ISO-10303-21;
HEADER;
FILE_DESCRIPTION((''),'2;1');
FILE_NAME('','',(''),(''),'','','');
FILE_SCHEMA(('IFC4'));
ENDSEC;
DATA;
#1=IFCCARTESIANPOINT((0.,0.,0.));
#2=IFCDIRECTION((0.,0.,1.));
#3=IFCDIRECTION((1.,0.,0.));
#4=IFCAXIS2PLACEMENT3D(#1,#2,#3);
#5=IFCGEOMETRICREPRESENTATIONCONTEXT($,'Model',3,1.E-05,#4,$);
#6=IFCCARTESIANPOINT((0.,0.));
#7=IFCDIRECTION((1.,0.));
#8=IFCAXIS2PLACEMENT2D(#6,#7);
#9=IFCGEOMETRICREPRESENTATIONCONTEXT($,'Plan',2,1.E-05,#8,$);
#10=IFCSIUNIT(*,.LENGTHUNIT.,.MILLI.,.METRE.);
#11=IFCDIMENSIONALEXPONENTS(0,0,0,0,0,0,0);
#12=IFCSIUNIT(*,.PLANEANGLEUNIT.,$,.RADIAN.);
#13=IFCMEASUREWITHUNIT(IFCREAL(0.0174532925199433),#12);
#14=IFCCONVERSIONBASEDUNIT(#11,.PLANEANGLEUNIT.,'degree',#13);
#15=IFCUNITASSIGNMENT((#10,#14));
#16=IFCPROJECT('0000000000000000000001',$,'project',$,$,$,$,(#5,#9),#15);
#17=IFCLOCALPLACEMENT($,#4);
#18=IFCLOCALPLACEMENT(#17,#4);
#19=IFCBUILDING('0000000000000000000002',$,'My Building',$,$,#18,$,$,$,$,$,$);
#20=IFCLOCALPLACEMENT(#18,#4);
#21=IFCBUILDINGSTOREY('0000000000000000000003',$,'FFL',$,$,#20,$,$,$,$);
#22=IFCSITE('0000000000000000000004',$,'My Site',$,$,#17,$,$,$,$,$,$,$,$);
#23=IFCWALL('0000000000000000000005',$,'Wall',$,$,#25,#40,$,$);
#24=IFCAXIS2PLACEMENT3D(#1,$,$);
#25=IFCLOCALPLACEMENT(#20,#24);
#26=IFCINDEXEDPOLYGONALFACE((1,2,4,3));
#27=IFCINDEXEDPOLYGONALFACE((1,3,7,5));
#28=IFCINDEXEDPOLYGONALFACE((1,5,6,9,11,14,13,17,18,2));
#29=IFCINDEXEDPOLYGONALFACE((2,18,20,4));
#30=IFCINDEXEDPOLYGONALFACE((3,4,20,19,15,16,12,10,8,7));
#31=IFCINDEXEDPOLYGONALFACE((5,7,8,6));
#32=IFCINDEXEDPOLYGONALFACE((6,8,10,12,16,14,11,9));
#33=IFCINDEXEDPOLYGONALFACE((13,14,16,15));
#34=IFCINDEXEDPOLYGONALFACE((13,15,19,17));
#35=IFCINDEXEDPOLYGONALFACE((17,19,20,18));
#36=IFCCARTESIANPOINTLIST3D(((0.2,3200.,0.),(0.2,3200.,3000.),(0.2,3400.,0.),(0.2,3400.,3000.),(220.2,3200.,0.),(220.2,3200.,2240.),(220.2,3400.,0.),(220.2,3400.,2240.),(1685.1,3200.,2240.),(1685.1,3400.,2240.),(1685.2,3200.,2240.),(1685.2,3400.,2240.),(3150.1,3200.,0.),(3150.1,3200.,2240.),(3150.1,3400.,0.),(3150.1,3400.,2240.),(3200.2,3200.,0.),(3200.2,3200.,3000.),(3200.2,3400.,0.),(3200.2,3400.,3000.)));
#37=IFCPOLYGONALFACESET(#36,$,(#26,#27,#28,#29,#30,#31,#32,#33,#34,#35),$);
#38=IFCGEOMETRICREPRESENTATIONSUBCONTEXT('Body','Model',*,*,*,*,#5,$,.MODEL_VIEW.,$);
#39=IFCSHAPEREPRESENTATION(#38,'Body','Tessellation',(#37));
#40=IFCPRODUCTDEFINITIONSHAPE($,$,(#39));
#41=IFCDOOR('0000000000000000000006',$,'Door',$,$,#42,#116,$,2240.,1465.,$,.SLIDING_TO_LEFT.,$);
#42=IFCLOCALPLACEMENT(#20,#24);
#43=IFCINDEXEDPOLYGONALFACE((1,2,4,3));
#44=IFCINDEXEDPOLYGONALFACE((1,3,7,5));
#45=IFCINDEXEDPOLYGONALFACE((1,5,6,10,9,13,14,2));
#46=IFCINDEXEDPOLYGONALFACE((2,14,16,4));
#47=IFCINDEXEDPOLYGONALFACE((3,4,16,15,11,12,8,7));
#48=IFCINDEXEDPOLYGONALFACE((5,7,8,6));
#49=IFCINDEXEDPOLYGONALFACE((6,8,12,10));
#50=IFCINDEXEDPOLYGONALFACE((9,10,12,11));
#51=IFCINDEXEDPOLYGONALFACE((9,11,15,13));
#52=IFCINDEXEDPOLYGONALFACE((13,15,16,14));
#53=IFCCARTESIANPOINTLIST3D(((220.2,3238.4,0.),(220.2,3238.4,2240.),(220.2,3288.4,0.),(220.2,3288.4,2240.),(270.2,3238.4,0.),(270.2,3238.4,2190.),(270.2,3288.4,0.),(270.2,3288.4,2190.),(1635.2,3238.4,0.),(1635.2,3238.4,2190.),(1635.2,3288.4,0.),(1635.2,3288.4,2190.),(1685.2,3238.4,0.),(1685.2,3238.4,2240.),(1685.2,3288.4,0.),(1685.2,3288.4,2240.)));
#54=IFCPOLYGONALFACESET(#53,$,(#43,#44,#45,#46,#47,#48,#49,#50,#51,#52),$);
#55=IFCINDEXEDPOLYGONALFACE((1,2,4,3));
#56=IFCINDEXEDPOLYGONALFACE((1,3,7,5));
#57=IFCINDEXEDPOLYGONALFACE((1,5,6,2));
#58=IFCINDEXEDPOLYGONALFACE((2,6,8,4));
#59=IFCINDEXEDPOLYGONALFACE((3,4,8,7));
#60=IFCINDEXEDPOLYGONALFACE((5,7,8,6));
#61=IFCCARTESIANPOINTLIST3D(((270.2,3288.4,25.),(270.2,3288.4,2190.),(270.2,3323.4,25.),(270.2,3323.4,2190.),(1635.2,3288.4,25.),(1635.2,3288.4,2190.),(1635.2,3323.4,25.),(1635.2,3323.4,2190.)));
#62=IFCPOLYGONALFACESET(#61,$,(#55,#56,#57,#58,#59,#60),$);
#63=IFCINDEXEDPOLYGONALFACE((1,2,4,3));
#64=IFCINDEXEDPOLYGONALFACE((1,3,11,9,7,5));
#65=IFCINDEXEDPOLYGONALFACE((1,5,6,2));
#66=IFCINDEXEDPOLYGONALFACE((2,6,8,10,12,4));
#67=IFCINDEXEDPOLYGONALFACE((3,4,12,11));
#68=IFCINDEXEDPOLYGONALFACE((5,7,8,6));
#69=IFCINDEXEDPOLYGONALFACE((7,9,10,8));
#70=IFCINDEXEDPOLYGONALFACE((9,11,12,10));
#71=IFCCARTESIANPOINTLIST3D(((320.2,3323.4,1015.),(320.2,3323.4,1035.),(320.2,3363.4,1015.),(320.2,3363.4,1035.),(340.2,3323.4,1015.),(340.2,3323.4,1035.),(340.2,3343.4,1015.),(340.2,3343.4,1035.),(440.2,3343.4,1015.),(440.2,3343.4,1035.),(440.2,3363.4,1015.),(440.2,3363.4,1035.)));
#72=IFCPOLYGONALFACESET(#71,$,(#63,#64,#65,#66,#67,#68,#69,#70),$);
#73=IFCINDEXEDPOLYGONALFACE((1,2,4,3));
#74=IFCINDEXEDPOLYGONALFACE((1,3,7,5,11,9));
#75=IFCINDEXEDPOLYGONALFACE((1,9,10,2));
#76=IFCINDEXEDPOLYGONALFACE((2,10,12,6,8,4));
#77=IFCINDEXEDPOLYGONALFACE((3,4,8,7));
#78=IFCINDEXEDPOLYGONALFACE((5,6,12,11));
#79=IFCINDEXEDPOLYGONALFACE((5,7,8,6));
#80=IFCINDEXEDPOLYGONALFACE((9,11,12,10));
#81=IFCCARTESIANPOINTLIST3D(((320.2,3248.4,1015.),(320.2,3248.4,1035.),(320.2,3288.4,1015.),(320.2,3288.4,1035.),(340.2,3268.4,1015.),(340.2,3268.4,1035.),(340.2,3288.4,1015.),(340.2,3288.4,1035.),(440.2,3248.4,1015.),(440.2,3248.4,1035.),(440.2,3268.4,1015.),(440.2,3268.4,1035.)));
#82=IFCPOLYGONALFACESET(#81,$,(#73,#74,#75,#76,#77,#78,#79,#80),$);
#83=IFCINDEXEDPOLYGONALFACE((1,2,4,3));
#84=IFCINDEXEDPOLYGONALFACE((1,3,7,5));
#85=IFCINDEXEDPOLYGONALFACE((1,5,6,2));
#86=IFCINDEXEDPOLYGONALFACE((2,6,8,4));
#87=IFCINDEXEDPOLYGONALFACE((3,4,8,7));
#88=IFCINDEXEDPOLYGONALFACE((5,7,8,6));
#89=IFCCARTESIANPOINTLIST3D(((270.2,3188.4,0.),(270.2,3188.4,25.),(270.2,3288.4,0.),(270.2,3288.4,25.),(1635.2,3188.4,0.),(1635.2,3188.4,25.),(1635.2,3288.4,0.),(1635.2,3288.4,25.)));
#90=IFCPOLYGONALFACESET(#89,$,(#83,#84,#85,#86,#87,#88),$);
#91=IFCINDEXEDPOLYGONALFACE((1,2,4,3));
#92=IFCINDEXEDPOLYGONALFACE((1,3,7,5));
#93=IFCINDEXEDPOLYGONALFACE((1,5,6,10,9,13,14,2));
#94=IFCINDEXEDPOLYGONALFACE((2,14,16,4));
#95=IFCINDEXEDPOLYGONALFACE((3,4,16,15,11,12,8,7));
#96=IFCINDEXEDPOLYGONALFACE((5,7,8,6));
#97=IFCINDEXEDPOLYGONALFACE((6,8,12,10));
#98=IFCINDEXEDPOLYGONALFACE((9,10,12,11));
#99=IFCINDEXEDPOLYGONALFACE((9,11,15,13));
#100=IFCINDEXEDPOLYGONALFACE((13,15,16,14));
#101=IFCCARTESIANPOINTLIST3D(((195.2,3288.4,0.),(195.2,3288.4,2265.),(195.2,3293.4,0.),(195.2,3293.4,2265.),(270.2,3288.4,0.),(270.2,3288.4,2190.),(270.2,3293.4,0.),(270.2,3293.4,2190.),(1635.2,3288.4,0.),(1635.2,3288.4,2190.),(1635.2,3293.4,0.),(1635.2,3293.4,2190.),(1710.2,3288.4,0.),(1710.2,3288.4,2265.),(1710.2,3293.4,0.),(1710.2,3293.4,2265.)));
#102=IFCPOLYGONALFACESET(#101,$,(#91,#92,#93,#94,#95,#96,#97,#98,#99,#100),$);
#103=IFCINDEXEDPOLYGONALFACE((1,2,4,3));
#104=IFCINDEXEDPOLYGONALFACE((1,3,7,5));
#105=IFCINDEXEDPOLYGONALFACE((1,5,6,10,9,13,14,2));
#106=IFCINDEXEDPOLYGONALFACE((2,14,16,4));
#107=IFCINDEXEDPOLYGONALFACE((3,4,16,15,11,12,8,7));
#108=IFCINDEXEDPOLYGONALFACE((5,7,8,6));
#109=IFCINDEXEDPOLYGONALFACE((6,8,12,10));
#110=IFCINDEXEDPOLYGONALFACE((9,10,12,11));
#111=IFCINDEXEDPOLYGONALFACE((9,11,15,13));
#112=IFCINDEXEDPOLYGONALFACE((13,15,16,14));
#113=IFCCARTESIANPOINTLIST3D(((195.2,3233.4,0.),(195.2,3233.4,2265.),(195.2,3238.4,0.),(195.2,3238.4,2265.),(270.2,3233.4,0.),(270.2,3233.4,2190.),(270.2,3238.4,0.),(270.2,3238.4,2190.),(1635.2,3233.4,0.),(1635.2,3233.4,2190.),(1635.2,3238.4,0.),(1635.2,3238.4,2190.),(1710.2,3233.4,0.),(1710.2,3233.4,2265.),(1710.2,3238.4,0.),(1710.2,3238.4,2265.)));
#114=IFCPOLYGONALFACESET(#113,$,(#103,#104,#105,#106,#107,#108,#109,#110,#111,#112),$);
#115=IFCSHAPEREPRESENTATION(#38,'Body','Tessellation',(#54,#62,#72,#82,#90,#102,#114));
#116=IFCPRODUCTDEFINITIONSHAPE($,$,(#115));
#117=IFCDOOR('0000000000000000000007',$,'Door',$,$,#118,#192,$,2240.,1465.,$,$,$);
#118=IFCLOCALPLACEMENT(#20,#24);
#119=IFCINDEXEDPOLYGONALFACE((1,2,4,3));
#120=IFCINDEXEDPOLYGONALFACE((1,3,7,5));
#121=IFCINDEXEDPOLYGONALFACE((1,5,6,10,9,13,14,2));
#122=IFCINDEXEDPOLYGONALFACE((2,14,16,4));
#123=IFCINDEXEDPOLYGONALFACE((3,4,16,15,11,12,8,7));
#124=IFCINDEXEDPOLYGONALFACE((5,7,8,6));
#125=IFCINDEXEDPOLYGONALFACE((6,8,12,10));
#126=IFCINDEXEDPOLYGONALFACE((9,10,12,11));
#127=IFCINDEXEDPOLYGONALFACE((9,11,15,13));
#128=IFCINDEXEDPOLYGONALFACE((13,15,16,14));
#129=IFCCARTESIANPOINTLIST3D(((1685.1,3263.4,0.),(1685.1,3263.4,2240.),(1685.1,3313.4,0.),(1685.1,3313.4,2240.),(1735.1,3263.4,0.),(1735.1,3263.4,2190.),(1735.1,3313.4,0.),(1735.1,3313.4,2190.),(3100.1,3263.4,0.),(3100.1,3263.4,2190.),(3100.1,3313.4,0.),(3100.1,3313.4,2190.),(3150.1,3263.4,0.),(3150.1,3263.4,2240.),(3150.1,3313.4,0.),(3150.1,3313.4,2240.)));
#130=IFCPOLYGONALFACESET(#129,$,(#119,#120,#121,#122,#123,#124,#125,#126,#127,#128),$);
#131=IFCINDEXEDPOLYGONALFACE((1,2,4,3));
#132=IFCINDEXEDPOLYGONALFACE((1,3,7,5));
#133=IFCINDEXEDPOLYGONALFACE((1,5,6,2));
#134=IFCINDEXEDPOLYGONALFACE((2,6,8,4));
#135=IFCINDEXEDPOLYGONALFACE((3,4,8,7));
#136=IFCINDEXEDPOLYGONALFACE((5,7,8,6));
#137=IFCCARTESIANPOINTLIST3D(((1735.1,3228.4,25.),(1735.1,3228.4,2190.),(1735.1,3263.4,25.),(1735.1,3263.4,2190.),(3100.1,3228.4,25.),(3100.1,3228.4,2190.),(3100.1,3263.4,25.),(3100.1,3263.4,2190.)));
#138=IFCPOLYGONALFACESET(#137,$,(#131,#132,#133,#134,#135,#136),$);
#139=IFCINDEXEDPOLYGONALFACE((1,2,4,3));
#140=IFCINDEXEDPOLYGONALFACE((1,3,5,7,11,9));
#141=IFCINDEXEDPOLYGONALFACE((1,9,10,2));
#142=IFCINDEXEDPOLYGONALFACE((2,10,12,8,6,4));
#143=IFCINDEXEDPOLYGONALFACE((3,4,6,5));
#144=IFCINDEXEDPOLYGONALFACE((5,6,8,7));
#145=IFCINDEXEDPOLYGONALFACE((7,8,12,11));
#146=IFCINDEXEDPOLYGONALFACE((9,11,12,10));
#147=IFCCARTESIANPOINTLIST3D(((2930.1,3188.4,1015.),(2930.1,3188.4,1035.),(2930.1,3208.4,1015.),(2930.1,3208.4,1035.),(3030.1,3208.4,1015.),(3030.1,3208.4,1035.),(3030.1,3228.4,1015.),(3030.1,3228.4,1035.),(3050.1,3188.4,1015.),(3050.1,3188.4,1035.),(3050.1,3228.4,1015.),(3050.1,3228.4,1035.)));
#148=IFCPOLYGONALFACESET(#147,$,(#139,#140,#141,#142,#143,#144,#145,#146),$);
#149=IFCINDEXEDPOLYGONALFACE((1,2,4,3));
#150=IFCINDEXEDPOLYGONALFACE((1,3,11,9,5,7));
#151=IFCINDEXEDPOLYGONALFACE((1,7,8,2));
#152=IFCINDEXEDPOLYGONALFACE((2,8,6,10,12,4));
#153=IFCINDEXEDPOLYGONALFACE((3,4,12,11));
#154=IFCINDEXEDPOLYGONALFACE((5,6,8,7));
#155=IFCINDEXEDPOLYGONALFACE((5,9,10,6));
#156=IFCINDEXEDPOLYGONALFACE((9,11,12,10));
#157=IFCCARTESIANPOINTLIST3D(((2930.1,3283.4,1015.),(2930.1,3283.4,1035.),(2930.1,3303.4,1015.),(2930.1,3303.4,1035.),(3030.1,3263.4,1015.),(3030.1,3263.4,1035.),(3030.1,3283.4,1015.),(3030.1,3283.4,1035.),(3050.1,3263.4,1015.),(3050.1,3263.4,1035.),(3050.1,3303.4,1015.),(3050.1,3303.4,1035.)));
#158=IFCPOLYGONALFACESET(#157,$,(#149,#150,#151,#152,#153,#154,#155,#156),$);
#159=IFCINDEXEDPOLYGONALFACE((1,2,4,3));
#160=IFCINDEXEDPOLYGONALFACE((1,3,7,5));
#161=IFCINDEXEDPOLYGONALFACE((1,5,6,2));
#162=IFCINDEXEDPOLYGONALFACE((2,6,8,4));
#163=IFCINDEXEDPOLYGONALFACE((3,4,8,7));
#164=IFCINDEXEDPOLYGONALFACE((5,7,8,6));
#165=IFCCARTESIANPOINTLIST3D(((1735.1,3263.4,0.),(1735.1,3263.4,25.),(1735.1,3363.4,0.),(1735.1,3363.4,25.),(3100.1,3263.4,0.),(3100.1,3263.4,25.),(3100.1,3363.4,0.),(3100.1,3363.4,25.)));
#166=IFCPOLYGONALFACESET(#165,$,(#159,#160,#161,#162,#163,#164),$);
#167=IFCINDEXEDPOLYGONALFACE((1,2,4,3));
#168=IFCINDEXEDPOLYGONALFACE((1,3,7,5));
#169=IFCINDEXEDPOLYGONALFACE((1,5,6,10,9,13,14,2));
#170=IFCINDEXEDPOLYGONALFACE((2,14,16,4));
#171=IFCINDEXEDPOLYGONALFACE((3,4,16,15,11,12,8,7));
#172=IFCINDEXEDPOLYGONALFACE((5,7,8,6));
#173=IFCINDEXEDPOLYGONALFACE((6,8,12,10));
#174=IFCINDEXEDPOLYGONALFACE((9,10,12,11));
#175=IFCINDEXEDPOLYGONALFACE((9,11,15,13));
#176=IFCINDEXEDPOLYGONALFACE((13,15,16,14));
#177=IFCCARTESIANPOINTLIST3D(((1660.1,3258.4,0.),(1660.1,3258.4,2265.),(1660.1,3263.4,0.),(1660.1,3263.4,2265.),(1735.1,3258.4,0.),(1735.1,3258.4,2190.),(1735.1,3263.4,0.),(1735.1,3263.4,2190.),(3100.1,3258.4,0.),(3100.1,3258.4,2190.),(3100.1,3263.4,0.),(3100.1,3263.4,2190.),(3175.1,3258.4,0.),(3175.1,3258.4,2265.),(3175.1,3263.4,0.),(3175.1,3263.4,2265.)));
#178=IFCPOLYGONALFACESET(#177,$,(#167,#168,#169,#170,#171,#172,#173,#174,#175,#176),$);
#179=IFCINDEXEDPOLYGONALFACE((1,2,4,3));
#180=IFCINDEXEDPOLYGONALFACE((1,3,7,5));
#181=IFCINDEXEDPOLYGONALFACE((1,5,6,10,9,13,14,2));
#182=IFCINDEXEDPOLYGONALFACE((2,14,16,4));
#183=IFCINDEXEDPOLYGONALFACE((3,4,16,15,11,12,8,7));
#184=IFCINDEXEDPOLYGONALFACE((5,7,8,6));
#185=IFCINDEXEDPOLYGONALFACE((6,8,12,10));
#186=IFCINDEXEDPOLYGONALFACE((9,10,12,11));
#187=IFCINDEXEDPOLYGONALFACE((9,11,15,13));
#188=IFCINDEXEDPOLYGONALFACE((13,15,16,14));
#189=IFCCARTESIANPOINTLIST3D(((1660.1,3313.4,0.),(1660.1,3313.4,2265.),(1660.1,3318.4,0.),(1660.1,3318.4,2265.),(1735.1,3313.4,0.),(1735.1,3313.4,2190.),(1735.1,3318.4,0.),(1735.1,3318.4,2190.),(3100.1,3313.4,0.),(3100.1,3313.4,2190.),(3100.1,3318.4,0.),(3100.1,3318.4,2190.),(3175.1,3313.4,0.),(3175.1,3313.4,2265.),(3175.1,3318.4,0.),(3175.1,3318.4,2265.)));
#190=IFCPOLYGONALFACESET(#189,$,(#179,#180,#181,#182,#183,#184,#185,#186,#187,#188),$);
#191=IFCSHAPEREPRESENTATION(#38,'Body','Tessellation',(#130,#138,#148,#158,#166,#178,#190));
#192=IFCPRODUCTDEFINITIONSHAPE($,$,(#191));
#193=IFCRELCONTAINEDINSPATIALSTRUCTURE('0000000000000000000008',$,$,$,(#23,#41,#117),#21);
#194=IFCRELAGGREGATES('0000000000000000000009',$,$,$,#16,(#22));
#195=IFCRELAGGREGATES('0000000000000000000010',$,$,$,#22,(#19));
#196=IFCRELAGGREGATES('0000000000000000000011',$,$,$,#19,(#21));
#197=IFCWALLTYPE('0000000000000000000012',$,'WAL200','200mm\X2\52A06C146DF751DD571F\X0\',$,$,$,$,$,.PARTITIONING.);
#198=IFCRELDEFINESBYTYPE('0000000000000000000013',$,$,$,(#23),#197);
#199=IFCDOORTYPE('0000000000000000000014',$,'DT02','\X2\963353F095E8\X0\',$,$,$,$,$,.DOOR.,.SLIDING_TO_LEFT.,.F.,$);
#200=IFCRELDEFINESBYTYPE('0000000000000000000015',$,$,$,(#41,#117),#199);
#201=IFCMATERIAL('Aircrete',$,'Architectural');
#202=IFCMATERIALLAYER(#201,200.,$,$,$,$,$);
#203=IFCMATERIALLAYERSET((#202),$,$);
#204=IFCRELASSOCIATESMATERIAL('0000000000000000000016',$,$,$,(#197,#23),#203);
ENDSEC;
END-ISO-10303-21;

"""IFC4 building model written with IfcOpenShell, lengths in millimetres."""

from ifc_helpers import new_model, entity, si_unit, converted_unit, frame, origin_with_axes, origin_2d_with_axis, place, context, subcontext, project, spatial, line, indexed_curve, outline, extrude, shape, source, transform, mapped, material, layer, layer_set, layer_usage, type_object, type_shapes, element, fill, save


model = new_model("IFC4")

# Units and contexts
model_context = context("Model", 3, precision=1e-05, world=origin_with_axes())
plan_context = context("Plan", 2, precision=1e-05, world=origin_2d_with_axis())
body_context_1 = subcontext(model_context, "Body", "Model", "MODEL_VIEW")
body_context_2 = subcontext(plan_context, "Body", "Plan", "PLAN_VIEW")
ifc_project = project(units=[si_unit("LENGTHUNIT", "METRE", prefix="MILLI"), converted_unit("PLANEANGLEUNIT", "degree", entity("IfcReal", 0.0174532925199433), si_unit("PLANEANGLEUNIT", "RADIAN"), dimensions=[0, 0, 0, 0, 0, 0, 0])], contexts=[model_context, plan_context])

# Site, building, storey
site_placement = place(None, origin_with_axes())
site = spatial("IfcSite", under=ifc_project, at=site_placement, Name="My Site")
building_placement = place(site_placement, origin_with_axes())
building = spatial("IfcBuilding", under=site, at=building_placement, Name="My Building")
storey_placement = place(building_placement, origin_with_axes())
storey = spatial("IfcBuildingStorey", under=building, at=storey_placement, Name="FFL")

# Shared definitions
ifc_material_1 = material(Name="Aircrete", Category="Architectural")

# Wall, openings, doors
ifc_layer_1 = layer(ifc_material_1, 200.0)
ifc_layer_set_1 = layer_set([ifc_layer_1])
ifc_layer_usage_1 = layer_usage(ifc_layer_set_1, "AXIS2", "NEGATIVE", 0.0)
wall_type_1 = type_object("IfcWallType", Name="WAL200", Description="200mm加气混凝土", PredefinedType="PARTITIONING", material=ifc_layer_set_1)
wall_1_placement = place(storey_placement, frame((3200.2, 3200.0, 0.0), z_axis=(0.0, 0.0, 1.0), x_axis=(-1.0, 0.0, 0.0)))
wall_1 = element("IfcWall", 1, at=wall_1_placement, inside=storey, type_object=wall_type_1, material=ifc_layer_usage_1, Name="Wall", context=body_context_1, shape_type="SweptSolid", body=[
    extrude(outline(indexed_curve([(0.0, -200.0), (0.0, 0.0), (3200.0, 0.0), (3200.0, -200.0)], segments=[line(1, 2, 3, 4, 1)])), origin_with_axes(), (0.0, 0.0, 1.0), 3000.0),
])
shared_shape_1 = source(origin_with_axes(), body_context_1, "Body", "SweptSolid", [
    extrude(outline(indexed_curve([(0.0, 0.0), (1465.0, 0.0), (1465.0, 2240.0), (0.0, 2240.0)], segments=[line(1, 2, 3, 4, 1)])), frame((0.0, -600.0, 0.0), z_axis=(0.0, -1.0, 0.0), x_axis=(1.0, 0.0, 0.0)), (0.0, 0.0, -1.0), 1200.0),
])
opening_1_placement = place(wall_1_placement, frame((1515.0, -88.5, 0.0), z_axis=(0.0, 0.0, 1.0), x_axis=(1.0, -0.000003, 0.0)))
opening_1 = element("IfcOpeningElement", 2, at=opening_1_placement, cuts=wall_1, PredefinedType="OPENING", context=body_context_1, shape_type="MappedRepresentation", body=[
    mapped(shared_shape_1, transform((0.0, 0.0, 0.0), x_axis=(1.0, 0.0, 0.0), y_axis=(0.0, 1.0, 0.0), z_axis=(0.0, 0.0, 1.0), scale=1.0)),
])
opening_2_placement = place(wall_1_placement, frame((1515.1, -63.5, 0.0), z_axis=(0.0, 0.0, 1.0), x_axis=(-1.0, 0.000001, 0.0)))
opening_2 = element("IfcOpeningElement", 3, at=opening_2_placement, cuts=wall_1, PredefinedType="OPENING", context=body_context_1, shape_type="MappedRepresentation", body=[
    mapped(shared_shape_1, transform((0.0, 0.0, 0.0), x_axis=(1.0, 0.0, 0.0), y_axis=(0.0, 1.0, 0.0), z_axis=(0.0, 0.0, 1.0), scale=1.0)),
])
door_type_1 = type_object("IfcDoorType", Name="DT02", Description="阳台门", OperationType="SLIDING_TO_LEFT", ParameterTakesPrecedence=False, PredefinedType="DOOR")
shared_shape_2 = source(origin_with_axes(), body_context_1, "Body", "SweptSolid", [
    extrude(outline(indexed_curve([(0.0, 0.0), (0.0, 2240.0), (1465.0, 2240.0), (1465.0, 0.0), (1415.0, 0.0), (1415.0, 2190.0), (50.0, 2190.0), (50.0, 0.0)], segments=[line(1, 2, 3, 4, 5, 6, 7, 8, 1)])), frame((0.0, 0.0, 0.0), z_axis=(0.0, -1.0, 0.0), x_axis=(1.0, 0.0, 0.0)), (0.0, 0.0, -1.0), 50.0),
    extrude(outline(indexed_curve([(0.0, 0.0), (1365.0, 0.0), (1365.0, 35.0), (0.0, 35.0)], segments=[line(1, 2, 3, 4, 1)])), frame((50.0, -35.0, 25.0), z_axis=(0.0, 0.0, 1.0), x_axis=(1.0, 0.0, 0.0)), (0.0, 0.0, 1.0), 2165.0),
    extrude(outline(indexed_curve([(0.0, 0.0), (0.0, -40.0), (-120.0, -40.0), (-120.0, -20.0), (-20.0, -20.0), (-20.0, 0.0)], segments=[line(1, 2, 3, 4, 5, 6, 1)])), frame((1365.0, -35.0, 1015.0), z_axis=(0.0, 0.0, 1.0), x_axis=(1.0, 0.0, 0.0)), (0.0, 0.0, 1.0), 20.0),
    extrude(outline(indexed_curve([(0.0, 0.0), (0.0, 40.0), (-120.0, 40.0), (-120.0, 20.0), (-20.0, 20.0), (-20.0, 0.0)], segments=[line(1, 2, 3, 4, 5, 6, 1)])), frame((1365.0, 0.0, 1015.0), z_axis=(0.0, 0.0, 1.0), x_axis=(1.0, 0.0, 0.0)), (0.0, 0.0, 1.0), 20.0),
    extrude(outline(indexed_curve([(0.0, 0.0), (1365.0, 0.0), (1365.0, 100.0), (0.0, 100.0)], segments=[line(1, 2, 3, 4, 1)])), frame((50.0, 0.0, 0.0), z_axis=(0.0, 0.0, 1.0), x_axis=(1.0, 0.0, 0.0)), (0.0, 0.0, 1.0), 25.0),
    extrude(outline(indexed_curve([(0.0, 0.0), (0.0, 2265.0), (1515.0, 2265.0), (1515.0, 0.0), (1440.0, 0.0), (1440.0, 2190.0), (75.0, 2190.0), (75.0, 0.0)], segments=[line(1, 2, 3, 4, 5, 6, 7, 8, 1)])), frame((-25.0, -5.0, 0.0), z_axis=(0.0, -1.0, 0.0), x_axis=(1.0, 0.0, 0.0)), (0.0, 0.0, -1.0), 5.0),
    extrude(outline(indexed_curve([(75.0, 0.0), (75.0, 2190.0), (1440.0, 2190.0), (1440.0, 0.0), (1515.0, 0.0), (1515.0, 2265.0), (0.0, 2265.0), (0.0, 0.0), (75.0, 0.0)])), frame((-25.0, 50.0, 0.0), z_axis=(0.0, -1.0, 0.0), x_axis=(1.0, 0.0, 0.0)), (0.0, 0.0, -1.0), 5.0),
])
shared_shape_3 = source(origin_with_axes(), body_context_2, "Body", "Curve2D", [
    entity("IfcIndexedPolyCurve", entity("IfcCartesianPointList2D", [[0.0, 0.0], [50.0, 0.0], [50.0, 50.0], [0.0, 50.0]]), [entity("IfcLineIndex", [1, 2, 3, 4, 1])]),
    entity("IfcIndexedPolyCurve", entity("IfcCartesianPointList2D", [[1465.0, 0.0], [1415.0, 0.0], [1415.0, 50.0], [1465.0, 50.0]]), [entity("IfcLineIndex", [1, 2, 3, 4, 1])]),
    entity("IfcIndexedPolyCurve", entity("IfcCartesianPointList2D", [[-632.5, -35.0], [732.5, -35.0], [732.5, 0.0], [-632.5, 0.0]]), [entity("IfcLineIndex", [1, 2, 3, 4, 1])]),
])
type_shapes(door_type_1, [shared_shape_2, shared_shape_3])
door_1_placement = place(opening_1_placement, frame((0.0, 0.0, 0.0), z_axis=(0.0, 0.0, 1.0), x_axis=(1.0, 0.0, 0.0)))
door_1 = element("IfcDoor", 4, at=door_1_placement, inside=storey, type_object=door_type_1, Name="Door", OperationType="SLIDING_TO_LEFT", OverallHeight=2240.0, OverallWidth=1465.0, shapes=[
    shape(body_context_1, "Body", "MappedRepresentation", [mapped(shared_shape_2, transform((0.0, 0.0, 0.0), x_axis=(1.0, 0.0, 0.0), y_axis=(0.0, 1.0, 0.0), z_axis=(0.0, 0.0, 1.0), scale=1.0))]),
    shape(body_context_2, "Body", "MappedRepresentation", [mapped(shared_shape_3, transform((0.0, 0.0, 0.0), x_axis=(1.0, 0.0, 0.0), y_axis=(0.0, 1.0, 0.0), z_axis=(0.0, 0.0, 1.0), scale=1.0))]),
])
fill(opening_1, door_1)
door_2_placement = place(opening_2_placement, frame((0.0, 0.0, 0.0), z_axis=(0.0, 0.0, 1.0), x_axis=(1.0, 0.0, 0.0)))
door_2 = element("IfcDoor", 5, at=door_2_placement, inside=storey, type_object=door_type_1, Name="Door", OverallHeight=2240.0, OverallWidth=1465.0, shapes=[
    shape(body_context_1, "Body", "MappedRepresentation", [mapped(shared_shape_2, transform((0.0, 0.0, 0.0), x_axis=(1.0, 0.0, 0.0), y_axis=(0.0, 1.0, 0.0), z_axis=(0.0, 0.0, 1.0), scale=1.0))]),
    shape(body_context_2, "Body", "MappedRepresentation", [mapped(shared_shape_3, transform((0.0, 0.0, 0.0), x_axis=(1.0, 0.0, 0.0), y_axis=(0.0, 1.0, 0.0), z_axis=(0.0, 0.0, 1.0), scale=1.0))]),
])
fill(opening_2, door_2)

save(model, "model.ifc")
